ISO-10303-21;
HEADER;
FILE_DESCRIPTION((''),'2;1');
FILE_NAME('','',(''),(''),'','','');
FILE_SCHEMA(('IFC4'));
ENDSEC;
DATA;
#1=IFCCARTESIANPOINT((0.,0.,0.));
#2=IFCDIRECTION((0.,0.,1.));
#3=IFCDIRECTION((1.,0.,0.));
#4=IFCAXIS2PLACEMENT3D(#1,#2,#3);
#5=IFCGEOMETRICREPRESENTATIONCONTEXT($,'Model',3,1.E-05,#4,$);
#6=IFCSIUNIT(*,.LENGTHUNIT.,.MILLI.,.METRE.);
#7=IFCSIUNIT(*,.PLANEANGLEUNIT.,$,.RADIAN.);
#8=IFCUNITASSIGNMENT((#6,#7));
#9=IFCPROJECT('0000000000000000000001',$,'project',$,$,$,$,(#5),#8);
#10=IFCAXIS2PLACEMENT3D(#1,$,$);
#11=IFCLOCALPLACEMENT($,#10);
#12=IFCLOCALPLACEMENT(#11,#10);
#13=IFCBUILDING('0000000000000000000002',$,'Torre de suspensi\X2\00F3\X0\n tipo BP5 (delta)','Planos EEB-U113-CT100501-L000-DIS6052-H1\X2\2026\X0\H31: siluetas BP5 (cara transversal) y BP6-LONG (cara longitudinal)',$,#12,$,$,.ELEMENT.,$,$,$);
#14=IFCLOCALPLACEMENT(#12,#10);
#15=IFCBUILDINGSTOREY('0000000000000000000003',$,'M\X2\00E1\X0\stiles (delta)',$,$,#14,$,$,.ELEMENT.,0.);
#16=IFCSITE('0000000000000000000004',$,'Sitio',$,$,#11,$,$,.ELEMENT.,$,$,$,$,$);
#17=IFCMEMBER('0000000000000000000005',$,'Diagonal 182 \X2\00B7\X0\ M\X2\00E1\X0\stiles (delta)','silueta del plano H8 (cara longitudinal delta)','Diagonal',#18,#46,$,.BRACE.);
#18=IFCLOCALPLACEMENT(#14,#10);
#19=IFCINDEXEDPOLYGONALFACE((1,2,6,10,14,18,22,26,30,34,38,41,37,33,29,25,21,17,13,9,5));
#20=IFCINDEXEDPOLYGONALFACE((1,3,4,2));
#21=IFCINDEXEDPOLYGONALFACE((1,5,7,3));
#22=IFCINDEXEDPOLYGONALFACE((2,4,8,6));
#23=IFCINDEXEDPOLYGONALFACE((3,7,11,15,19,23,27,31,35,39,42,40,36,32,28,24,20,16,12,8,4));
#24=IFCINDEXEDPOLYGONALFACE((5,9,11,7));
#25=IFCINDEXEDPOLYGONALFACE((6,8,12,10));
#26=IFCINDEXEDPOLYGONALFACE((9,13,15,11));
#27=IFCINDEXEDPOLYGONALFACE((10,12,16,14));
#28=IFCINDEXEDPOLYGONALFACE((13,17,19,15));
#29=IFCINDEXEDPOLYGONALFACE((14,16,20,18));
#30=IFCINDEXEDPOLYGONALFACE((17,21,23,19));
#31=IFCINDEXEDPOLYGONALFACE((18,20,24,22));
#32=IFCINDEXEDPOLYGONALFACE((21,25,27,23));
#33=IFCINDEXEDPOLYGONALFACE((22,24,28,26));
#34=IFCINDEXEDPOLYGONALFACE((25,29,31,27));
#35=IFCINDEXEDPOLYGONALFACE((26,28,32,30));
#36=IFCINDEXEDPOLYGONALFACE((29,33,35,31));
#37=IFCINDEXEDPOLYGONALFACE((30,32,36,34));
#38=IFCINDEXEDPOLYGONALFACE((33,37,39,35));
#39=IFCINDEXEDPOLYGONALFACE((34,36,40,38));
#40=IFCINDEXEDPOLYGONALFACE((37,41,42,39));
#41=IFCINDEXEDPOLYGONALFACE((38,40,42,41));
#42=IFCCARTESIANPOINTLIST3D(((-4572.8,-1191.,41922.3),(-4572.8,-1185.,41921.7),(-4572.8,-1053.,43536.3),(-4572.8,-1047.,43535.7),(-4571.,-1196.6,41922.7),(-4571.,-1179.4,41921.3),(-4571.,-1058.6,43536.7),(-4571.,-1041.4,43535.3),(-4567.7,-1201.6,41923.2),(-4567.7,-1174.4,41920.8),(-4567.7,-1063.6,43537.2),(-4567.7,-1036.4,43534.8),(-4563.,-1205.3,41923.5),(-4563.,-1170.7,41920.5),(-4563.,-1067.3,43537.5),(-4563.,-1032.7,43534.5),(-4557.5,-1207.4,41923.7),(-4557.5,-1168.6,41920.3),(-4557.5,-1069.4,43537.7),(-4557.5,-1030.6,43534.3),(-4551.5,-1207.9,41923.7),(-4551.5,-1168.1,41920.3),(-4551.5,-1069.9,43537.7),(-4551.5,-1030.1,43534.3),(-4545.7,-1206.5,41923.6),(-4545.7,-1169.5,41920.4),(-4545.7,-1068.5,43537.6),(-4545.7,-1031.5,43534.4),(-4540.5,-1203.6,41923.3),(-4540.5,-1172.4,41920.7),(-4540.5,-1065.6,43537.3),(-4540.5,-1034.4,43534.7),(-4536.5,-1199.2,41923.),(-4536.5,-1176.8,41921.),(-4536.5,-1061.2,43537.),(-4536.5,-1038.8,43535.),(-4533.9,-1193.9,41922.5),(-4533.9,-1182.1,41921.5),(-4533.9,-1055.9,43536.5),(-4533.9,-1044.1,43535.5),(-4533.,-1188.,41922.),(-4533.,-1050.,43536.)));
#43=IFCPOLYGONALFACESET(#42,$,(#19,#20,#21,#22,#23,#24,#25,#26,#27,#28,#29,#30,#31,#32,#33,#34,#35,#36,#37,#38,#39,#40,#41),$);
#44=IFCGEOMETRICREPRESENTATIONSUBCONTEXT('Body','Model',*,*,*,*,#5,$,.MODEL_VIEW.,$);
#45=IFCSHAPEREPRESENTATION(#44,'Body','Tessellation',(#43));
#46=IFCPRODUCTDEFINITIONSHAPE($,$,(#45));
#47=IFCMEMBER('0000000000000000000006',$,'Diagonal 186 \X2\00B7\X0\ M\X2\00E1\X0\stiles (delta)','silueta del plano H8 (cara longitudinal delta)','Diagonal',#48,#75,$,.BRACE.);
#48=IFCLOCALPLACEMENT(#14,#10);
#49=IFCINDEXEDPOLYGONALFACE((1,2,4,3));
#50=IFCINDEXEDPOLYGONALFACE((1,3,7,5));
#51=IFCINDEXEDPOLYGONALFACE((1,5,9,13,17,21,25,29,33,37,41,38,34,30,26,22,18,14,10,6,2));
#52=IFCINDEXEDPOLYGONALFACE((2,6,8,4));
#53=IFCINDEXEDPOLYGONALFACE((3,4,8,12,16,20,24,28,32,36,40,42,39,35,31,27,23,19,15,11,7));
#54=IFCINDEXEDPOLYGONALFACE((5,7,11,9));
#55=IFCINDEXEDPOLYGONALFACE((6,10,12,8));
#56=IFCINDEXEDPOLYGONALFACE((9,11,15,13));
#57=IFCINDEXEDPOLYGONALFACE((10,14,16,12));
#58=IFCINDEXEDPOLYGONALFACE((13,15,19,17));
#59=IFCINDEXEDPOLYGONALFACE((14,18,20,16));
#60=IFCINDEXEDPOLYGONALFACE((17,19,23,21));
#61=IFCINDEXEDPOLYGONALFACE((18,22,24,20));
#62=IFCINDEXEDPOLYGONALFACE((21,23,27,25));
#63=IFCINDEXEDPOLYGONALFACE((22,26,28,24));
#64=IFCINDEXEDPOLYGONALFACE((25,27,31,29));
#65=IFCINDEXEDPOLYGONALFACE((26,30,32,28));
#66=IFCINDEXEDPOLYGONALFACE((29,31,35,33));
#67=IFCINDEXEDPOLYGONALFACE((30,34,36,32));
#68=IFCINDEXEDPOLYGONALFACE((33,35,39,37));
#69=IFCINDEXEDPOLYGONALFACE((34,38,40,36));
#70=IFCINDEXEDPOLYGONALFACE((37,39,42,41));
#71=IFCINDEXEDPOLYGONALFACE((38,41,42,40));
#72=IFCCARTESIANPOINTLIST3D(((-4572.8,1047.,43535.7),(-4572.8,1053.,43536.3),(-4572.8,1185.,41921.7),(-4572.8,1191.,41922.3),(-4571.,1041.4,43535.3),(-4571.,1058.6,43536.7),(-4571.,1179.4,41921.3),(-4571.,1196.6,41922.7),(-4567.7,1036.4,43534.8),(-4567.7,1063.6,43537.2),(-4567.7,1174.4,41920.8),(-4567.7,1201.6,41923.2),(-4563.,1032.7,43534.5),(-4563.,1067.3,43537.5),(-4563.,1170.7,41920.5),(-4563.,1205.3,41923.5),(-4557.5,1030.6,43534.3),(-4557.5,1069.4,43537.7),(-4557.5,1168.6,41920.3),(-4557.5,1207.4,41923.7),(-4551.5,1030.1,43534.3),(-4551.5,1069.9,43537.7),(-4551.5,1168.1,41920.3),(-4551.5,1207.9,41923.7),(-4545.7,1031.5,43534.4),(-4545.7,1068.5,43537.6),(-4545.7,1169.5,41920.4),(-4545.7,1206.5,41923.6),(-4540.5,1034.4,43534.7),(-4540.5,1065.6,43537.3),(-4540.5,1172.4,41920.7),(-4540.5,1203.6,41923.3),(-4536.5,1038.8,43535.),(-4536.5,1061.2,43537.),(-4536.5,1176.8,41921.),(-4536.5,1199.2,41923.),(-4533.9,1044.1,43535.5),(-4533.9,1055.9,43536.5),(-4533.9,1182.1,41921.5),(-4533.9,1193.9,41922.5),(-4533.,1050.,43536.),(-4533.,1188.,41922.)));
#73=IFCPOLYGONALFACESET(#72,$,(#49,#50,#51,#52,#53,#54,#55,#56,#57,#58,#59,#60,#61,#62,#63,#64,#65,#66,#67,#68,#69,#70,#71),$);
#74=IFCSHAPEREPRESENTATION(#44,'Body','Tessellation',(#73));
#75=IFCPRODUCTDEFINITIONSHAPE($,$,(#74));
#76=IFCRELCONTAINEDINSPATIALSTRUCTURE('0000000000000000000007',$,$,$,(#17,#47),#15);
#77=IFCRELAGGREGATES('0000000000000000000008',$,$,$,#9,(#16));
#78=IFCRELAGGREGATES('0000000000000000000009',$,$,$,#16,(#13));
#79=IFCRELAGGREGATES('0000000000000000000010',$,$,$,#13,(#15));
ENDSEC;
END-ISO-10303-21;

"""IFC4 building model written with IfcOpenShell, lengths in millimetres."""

from ifc_helpers import new_model, si_unit, frame, origin, origin_with_axes, place, context, subcontext, project, spatial, circle, extrude, element, save


model = new_model("IFC4")

# Units and contexts
model_context = context("Model", 3, precision=1e-05, world=origin_with_axes())
body_context = subcontext(model_context, "Body", "Model", "MODEL_VIEW")
ifc_project = project(units=[si_unit("LENGTHUNIT", "METRE", prefix="MILLI"), si_unit("PLANEANGLEUNIT", "RADIAN")], contexts=[model_context])

# Site, building, storey
site_placement = place(None, origin())
site = spatial("IfcSite", under=ifc_project, at=site_placement, Name="Sitio", CompositionType="ELEMENT")
building_placement = place(site_placement, origin())
building = spatial("IfcBuilding", under=site, at=building_placement, Name="Torre de suspensión tipo BP5 (delta)", Description="Planos EEB-U113-CT100501-L000-DIS6052-H1…H31: siluetas BP5 (cara transversal) y BP6-LONG (cara longitudinal)", CompositionType="ELEMENT")
storey_placement = place(building_placement, origin())
storey = spatial("IfcBuildingStorey", under=building, at=storey_placement, Name="Mástiles (delta)", CompositionType="ELEMENT", Elevation=0.0)

# Members
for number, where, z_axis, x_axis, name in (
    (1, (-4553.0, -1050.0, 43536.0), (0.0, -0.085191, -0.996365), (1.0, 0.0, 0.0), "Diagonal 182 · Mástiles (delta)"),
    (2, (-4553.0, 1050.0, 43536.0), (0.0, 0.085191, -0.996365), (1.0, 0.0, 0.0), "Diagonal 186 · Mástiles (delta)"),
):
    element("IfcMember", number, at=place(storey_placement, frame(where, z_axis=z_axis, x_axis=x_axis)), inside=storey, Name=name, Description="silueta del plano H8 (cara longitudinal delta)", ObjectType="Diagonal", PredefinedType="BRACE", context=body_context, shape_type="SweptSolid", body=[
        extrude(circle(Radius=20.0), None, (0.0, 0.0, 1.0), 1619.9),
    ])

save(model, "model.ifc")
